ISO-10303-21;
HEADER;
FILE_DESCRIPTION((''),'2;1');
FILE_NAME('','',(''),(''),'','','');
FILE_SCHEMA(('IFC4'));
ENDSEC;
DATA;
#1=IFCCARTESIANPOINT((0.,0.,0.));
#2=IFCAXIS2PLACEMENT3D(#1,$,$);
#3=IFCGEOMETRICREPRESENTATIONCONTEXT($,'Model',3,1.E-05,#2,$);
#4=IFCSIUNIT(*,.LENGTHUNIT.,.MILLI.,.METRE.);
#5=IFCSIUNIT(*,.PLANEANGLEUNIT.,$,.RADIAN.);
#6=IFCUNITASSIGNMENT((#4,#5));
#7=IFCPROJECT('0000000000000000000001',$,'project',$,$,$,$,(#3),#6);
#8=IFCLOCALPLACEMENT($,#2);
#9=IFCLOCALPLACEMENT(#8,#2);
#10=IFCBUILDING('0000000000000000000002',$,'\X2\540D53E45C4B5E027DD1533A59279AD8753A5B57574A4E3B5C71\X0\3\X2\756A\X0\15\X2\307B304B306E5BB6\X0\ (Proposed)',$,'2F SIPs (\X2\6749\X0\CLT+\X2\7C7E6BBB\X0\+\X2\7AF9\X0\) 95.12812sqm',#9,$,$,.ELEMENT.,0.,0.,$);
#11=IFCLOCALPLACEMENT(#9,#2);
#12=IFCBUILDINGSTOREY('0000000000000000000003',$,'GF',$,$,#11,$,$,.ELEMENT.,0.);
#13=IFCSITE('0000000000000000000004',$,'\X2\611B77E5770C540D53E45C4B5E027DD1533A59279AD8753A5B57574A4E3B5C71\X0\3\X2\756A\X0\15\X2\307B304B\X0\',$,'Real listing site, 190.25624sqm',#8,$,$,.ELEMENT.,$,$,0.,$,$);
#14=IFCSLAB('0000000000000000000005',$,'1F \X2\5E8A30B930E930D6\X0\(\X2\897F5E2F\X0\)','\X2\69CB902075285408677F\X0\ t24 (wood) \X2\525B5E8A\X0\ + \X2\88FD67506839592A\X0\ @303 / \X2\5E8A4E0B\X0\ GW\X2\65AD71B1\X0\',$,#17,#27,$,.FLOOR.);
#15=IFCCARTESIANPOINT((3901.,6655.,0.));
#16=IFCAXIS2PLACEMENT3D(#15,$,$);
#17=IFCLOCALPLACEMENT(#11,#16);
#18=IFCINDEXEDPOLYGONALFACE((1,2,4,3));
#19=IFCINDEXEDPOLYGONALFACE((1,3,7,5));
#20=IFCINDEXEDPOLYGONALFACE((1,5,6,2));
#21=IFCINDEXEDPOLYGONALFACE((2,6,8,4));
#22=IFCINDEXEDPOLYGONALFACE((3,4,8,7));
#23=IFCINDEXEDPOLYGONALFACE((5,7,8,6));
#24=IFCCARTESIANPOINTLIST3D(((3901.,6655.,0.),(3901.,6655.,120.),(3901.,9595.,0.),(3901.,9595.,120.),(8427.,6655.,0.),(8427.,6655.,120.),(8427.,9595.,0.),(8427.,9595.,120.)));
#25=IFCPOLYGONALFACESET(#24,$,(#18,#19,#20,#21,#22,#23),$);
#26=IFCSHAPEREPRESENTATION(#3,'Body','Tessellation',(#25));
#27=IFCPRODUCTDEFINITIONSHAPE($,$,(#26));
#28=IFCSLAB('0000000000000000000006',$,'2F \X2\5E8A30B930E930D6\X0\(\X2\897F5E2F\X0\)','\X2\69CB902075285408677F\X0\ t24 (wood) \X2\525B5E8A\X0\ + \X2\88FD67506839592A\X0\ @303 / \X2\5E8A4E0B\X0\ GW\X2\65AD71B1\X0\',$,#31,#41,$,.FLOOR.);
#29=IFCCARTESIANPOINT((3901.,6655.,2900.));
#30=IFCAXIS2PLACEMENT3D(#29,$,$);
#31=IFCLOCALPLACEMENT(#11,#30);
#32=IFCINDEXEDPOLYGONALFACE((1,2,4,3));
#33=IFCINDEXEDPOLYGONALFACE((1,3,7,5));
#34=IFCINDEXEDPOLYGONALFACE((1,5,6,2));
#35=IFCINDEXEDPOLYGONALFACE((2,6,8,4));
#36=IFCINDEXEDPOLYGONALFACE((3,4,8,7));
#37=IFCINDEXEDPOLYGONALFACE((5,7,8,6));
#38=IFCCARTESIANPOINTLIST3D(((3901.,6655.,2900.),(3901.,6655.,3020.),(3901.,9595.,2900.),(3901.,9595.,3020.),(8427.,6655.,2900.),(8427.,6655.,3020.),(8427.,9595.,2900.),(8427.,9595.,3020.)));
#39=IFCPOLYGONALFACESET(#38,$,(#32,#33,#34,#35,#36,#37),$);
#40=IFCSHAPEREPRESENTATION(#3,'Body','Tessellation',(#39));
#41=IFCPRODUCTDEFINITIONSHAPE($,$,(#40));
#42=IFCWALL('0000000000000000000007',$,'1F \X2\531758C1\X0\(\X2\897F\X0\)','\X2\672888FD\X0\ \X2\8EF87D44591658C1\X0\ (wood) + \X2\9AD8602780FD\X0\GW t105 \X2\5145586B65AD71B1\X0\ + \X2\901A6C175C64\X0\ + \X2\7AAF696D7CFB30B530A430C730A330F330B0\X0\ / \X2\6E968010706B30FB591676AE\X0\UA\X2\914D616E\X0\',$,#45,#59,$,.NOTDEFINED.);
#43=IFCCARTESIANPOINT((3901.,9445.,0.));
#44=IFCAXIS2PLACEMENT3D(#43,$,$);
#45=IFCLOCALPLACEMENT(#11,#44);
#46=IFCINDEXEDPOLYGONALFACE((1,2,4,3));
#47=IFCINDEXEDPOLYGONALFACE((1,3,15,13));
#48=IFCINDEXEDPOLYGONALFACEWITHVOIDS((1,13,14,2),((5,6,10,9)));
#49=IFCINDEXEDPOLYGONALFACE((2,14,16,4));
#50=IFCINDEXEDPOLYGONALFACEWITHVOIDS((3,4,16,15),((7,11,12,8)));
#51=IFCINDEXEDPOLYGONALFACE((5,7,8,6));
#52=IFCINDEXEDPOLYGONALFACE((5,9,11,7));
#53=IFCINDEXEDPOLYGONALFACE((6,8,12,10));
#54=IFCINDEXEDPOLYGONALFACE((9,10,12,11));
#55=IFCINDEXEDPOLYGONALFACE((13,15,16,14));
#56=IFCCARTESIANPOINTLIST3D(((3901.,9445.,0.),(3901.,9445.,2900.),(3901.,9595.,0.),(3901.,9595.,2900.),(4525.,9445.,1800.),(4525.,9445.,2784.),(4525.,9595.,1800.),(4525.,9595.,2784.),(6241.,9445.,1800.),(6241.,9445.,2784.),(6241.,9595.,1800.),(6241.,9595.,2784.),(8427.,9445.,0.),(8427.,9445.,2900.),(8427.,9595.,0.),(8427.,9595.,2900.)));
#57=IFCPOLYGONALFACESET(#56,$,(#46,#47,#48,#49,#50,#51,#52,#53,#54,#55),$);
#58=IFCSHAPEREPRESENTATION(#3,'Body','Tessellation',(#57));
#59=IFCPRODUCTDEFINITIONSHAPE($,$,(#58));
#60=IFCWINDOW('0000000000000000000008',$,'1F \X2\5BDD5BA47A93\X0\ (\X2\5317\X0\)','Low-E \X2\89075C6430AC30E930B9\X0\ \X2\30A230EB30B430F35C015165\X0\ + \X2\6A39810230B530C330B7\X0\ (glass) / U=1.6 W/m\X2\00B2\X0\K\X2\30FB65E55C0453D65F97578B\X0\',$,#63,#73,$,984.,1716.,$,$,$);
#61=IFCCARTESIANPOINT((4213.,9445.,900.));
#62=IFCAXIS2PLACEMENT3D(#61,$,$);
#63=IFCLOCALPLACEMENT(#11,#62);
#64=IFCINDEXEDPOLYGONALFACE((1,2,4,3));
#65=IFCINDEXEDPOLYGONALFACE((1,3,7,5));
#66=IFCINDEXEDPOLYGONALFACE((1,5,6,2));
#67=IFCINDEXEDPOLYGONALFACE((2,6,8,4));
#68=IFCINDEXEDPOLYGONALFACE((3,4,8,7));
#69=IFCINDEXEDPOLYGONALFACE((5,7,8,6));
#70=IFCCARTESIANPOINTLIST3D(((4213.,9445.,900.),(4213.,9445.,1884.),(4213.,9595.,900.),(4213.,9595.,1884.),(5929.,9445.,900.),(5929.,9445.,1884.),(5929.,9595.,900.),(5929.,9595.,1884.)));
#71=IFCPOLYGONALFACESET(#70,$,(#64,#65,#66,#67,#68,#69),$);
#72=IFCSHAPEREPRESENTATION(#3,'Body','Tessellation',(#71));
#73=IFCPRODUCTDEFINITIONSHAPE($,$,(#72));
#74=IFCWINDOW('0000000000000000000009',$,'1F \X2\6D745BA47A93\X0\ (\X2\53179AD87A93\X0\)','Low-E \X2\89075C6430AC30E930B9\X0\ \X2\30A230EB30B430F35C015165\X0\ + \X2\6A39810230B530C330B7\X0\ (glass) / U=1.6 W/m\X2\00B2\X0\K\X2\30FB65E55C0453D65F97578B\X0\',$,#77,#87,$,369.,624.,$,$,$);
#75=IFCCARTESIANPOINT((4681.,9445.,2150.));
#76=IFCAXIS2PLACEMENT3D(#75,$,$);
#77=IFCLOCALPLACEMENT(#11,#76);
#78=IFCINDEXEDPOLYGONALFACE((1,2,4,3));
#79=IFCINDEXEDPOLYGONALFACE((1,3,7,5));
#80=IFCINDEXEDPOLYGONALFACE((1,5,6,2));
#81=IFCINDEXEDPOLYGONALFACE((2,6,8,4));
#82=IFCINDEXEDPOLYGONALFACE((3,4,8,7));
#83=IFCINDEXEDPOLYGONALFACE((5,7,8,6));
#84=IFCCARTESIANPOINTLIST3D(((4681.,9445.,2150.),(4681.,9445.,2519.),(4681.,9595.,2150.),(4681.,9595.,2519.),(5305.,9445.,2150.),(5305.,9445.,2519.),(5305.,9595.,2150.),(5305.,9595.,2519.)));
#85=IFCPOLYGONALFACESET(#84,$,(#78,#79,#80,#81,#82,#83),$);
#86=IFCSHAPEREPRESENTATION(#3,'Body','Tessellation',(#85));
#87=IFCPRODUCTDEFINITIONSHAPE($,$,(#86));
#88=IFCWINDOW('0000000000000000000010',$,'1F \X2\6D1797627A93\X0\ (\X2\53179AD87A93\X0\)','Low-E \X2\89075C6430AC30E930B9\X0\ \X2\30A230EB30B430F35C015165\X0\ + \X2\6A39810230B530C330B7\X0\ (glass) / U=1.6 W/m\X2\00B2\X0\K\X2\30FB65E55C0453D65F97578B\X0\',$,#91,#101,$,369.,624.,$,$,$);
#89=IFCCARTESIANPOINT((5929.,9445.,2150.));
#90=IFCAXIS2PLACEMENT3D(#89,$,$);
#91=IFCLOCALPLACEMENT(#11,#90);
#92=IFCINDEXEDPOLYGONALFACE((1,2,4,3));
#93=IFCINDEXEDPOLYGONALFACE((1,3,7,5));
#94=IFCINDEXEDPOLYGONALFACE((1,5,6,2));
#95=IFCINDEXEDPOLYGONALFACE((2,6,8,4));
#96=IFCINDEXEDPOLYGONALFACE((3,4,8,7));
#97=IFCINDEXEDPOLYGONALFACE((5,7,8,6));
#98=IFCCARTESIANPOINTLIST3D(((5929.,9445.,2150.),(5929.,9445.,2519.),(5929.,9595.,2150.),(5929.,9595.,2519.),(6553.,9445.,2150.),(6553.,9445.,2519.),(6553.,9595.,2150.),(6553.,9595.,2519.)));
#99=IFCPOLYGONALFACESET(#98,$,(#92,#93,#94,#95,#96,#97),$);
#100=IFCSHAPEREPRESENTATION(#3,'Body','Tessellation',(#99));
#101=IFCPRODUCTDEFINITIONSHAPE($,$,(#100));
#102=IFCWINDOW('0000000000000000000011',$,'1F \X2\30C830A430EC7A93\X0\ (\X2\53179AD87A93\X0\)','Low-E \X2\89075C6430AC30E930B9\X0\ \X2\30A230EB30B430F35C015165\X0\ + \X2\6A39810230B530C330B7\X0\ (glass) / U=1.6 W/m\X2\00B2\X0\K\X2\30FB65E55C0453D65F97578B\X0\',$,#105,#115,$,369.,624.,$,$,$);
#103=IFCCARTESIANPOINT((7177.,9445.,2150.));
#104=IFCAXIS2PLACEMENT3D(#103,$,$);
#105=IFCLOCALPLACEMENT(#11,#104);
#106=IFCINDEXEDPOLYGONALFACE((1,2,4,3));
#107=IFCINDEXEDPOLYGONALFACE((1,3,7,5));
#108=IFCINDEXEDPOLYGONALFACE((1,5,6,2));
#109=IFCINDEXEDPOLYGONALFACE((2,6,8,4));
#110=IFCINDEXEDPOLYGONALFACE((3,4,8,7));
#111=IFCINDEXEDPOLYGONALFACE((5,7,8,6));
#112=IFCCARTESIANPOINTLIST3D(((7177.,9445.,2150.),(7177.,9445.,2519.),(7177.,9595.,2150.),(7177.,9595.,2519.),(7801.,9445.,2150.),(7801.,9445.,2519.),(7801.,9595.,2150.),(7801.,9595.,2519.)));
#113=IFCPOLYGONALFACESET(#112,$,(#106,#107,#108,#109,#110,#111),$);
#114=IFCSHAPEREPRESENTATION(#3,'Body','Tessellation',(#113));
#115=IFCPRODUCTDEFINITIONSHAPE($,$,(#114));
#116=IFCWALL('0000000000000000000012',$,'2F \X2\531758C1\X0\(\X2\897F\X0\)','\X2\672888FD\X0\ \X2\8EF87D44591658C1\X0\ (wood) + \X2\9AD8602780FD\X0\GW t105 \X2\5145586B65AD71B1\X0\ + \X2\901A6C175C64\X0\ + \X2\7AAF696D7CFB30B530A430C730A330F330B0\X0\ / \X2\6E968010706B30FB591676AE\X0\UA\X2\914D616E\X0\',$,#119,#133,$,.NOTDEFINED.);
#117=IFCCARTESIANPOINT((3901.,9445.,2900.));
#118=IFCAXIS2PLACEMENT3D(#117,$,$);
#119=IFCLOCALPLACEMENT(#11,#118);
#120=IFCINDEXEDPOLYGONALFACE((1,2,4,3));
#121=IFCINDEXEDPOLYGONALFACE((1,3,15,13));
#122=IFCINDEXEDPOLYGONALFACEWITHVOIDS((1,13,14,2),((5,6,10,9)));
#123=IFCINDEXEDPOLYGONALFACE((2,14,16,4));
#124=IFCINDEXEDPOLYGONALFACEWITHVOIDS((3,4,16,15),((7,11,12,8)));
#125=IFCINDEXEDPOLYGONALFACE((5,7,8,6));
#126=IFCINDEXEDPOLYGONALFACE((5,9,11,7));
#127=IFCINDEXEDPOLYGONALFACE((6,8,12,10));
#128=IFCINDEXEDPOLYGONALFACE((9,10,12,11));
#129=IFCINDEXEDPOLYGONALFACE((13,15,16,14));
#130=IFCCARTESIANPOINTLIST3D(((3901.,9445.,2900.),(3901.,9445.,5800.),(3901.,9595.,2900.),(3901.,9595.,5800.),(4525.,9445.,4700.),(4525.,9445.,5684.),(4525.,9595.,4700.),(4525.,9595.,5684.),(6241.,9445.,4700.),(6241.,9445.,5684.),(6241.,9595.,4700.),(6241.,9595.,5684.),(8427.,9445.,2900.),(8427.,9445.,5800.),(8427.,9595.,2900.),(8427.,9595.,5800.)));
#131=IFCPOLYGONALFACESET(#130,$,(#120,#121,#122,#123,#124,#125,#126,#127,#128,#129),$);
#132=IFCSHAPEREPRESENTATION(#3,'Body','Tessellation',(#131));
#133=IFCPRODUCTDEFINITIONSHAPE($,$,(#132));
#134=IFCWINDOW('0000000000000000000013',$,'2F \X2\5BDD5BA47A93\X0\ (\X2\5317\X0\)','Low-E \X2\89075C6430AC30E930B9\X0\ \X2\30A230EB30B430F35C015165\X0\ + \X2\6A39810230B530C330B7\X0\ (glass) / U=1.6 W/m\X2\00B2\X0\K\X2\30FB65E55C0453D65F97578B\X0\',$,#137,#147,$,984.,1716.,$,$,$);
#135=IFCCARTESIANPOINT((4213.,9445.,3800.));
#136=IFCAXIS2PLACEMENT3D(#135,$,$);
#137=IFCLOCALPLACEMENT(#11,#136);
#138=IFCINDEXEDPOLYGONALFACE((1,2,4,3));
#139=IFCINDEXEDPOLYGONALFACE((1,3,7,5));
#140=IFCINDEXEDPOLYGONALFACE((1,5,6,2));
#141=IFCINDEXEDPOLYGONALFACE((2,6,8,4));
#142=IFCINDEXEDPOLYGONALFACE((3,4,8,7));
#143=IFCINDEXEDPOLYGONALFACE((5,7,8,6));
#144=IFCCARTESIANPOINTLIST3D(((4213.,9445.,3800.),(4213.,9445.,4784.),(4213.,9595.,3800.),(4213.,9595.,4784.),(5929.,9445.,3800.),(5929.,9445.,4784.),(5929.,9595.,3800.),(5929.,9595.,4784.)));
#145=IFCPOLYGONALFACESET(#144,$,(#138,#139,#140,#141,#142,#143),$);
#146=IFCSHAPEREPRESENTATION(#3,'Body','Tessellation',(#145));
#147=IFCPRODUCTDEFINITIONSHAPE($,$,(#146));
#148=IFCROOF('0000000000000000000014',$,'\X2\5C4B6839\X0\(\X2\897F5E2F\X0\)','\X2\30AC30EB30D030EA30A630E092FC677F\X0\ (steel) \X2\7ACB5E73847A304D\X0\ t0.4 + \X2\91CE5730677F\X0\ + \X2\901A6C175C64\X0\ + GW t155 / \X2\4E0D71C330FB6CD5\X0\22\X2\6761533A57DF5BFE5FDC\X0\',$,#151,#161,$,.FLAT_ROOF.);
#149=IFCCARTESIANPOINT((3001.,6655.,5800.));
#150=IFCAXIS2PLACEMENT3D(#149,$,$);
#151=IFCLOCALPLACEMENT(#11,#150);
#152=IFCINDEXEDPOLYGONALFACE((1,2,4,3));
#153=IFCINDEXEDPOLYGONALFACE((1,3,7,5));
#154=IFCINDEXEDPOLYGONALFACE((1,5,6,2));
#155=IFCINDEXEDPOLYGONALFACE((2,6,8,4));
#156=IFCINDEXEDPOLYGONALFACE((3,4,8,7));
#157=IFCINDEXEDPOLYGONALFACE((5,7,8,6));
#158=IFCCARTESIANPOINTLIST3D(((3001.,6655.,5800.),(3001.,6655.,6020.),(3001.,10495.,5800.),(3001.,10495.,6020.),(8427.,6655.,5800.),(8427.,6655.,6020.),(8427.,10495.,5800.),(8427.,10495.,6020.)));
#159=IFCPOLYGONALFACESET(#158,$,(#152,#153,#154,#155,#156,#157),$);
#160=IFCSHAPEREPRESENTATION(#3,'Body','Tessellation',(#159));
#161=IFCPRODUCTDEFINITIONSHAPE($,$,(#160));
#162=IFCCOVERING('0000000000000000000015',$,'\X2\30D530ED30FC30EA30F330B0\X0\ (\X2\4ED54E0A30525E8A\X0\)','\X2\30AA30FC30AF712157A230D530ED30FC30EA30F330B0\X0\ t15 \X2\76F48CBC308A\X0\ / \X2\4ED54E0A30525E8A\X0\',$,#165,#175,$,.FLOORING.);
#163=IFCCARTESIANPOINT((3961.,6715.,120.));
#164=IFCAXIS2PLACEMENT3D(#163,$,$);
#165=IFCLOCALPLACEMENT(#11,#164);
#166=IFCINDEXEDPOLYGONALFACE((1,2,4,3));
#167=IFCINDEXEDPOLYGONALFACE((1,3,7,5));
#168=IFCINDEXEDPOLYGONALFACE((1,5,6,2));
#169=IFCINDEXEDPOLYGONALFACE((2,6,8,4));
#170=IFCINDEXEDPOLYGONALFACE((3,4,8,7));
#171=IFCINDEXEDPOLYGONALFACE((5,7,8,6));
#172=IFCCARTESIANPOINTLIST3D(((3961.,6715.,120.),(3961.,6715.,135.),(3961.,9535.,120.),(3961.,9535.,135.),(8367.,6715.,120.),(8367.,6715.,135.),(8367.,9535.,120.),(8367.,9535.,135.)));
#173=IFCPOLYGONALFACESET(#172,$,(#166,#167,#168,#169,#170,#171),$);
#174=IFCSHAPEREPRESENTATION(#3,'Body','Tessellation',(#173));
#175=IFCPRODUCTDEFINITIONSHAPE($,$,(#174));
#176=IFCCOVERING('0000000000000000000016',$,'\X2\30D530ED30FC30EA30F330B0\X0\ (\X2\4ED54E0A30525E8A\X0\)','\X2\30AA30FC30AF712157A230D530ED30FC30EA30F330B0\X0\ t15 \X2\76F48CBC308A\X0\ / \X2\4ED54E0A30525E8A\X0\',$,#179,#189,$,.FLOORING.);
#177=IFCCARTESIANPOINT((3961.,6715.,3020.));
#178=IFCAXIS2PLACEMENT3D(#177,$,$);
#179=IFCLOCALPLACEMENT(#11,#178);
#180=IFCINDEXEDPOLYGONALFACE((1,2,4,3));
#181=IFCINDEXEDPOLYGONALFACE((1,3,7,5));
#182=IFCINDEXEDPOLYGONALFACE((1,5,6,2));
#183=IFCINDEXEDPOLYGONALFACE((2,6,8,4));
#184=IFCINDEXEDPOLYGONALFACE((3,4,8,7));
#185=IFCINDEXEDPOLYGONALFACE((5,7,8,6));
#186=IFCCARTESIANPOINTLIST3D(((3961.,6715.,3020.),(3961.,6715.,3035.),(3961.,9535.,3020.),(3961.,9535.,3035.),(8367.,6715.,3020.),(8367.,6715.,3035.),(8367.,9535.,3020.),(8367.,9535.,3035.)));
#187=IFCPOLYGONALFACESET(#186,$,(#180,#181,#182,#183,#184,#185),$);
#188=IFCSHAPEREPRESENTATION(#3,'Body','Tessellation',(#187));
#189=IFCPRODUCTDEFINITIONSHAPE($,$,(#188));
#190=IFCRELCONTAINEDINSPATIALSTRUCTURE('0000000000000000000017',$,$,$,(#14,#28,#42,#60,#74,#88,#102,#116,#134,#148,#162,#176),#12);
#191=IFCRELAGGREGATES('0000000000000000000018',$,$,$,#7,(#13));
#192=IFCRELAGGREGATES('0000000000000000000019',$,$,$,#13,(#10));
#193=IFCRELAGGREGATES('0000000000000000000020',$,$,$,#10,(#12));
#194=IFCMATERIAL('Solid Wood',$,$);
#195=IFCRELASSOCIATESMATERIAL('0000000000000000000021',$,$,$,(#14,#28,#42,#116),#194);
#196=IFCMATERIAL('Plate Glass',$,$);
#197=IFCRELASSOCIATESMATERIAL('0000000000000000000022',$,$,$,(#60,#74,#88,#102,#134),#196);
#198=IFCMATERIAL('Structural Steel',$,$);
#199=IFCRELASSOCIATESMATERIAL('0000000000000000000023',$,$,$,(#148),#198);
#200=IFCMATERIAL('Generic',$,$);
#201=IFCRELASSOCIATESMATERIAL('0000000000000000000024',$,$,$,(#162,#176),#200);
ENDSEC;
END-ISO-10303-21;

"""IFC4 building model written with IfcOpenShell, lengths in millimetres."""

from ifc_helpers import new_model, si_unit, frame, frame_2d, origin, place, context, project, spatial, rectangle, extrude, material, element, fill, save


model = new_model("IFC4")

# Units and contexts
model_context = context("Model", 3, precision=1e-05, world=origin())
ifc_project = project(units=[si_unit("LENGTHUNIT", "METRE", prefix="MILLI"), si_unit("PLANEANGLEUNIT", "RADIAN")], contexts=[model_context])

# Site, building, storey
site_placement = place(None, origin())
site = spatial("IfcSite", under=ifc_project, at=site_placement, Name="愛知県名古屋市緑区大高町字坊主山3番15ほか", ObjectType="Real listing site, 190.25624sqm", CompositionType="ELEMENT", RefElevation=0.0)
building_placement = place(site_placement, origin())
building = spatial("IfcBuilding", under=site, at=building_placement, Name="名古屋市緑区大高町字坊主山3番15ほかの家 (Proposed)", ObjectType="2F SIPs (杉CLT+籾殻+竹) 95.12812sqm", CompositionType="ELEMENT", ElevationOfRefHeight=0.0, ElevationOfTerrain=0.0)
storey_placement = place(building_placement, origin())
storey = spatial("IfcBuildingStorey", under=building, at=storey_placement, Name="GF", CompositionType="ELEMENT", Elevation=0.0)

# Slabs
ifc_material_1 = material(Name="Solid Wood")
slab_1_placement = place(storey_placement, frame((3901.0, 6655.0, 0.0)))
element("IfcSlab", 1, at=slab_1_placement, inside=storey, material=ifc_material_1, Name="1F 床スラブ(西帯)", Description="構造用合板 t24 (wood) 剛床 + 製材根太 @303 / 床下 GW断熱", PredefinedType="FLOOR", context=model_context, shape_type="SweptSolid", body=[
    extrude(rectangle(XDim=4526.0, YDim=2940.0, at=frame_2d((2263.0, 1470.0))), frame((3901.0, 6655.0, 0.0)), (0.0, 0.0, 1.0), 120.0),
])
slab_2_placement = place(storey_placement, frame((3901.0, 6655.0, 2900.0)))
element("IfcSlab", 2, at=slab_2_placement, inside=storey, material=ifc_material_1, Name="2F 床スラブ(西帯)", Description="構造用合板 t24 (wood) 剛床 + 製材根太 @303 / 床下 GW断熱", PredefinedType="FLOOR", context=model_context, shape_type="SweptSolid", body=[
    extrude(rectangle(XDim=4526.0, YDim=2940.0, at=frame_2d((2263.0, 1470.0))), frame((3901.0, 6655.0, 2900.0)), (0.0, 0.0, 1.0), 120.0),
])

# Wall, openings, windows
wall_1_placement = place(storey_placement, frame((3901.0, 9445.0, 0.0)))
wall_1 = element("IfcWall", 3, at=wall_1_placement, inside=storey, material=ifc_material_1, Name="1F 北壁(西)", Description="木製 軸組外壁 (wood) + 高性能GW t105 充填断熱 + 通気層 + 窯業系サイディング / 準耐火・外皮UA配慮", PredefinedType="NOTDEFINED", context=model_context, shape_type="SweptSolid", body=[
    extrude(rectangle(XDim=4526.0, YDim=150.0, at=frame_2d((2263.0, 75.0))), frame((3901.0, 9445.0, 0.0)), (0.0, 0.0, 1.0), 2900.0),
])
opening_1_placement = place(storey_placement, frame((4213.0, 9445.0, 900.0)))
opening_1 = element("IfcOpeningElement", 4, at=opening_1_placement, cuts=wall_1, PredefinedType="NOTDEFINED", context=model_context, shape_type="SweptSolid", body=[
    extrude(rectangle(XDim=1716.0, YDim=150.0, at=frame_2d((858.0, 75.0))), frame((4213.0, 9445.0, 900.0)), (0.0, 0.0, 1.0), 984.0),
])
opening_2_placement = place(storey_placement, frame((4681.0, 9445.0, 2150.0)))
opening_2 = element("IfcOpeningElement", 5, at=opening_2_placement, cuts=wall_1, PredefinedType="NOTDEFINED", context=model_context, shape_type="SweptSolid", body=[
    extrude(rectangle(XDim=624.0, YDim=150.0, at=frame_2d((312.0, 75.0))), frame((4681.0, 9445.0, 2150.0)), (0.0, 0.0, 1.0), 369.0),
])
opening_3_placement = place(storey_placement, frame((5929.0, 9445.0, 2150.0)))
opening_3 = element("IfcOpeningElement", 6, at=opening_3_placement, cuts=wall_1, PredefinedType="NOTDEFINED", context=model_context, shape_type="SweptSolid", body=[
    extrude(rectangle(XDim=624.0, YDim=150.0, at=frame_2d((312.0, 75.0))), frame((5929.0, 9445.0, 2150.0)), (0.0, 0.0, 1.0), 369.0),
])
opening_4_placement = place(storey_placement, frame((7177.0, 9445.0, 2150.0)))
opening_4 = element("IfcOpeningElement", 7, at=opening_4_placement, cuts=wall_1, PredefinedType="NOTDEFINED", context=model_context, shape_type="SweptSolid", body=[
    extrude(rectangle(XDim=624.0, YDim=150.0, at=frame_2d((312.0, 75.0))), frame((7177.0, 9445.0, 2150.0)), (0.0, 0.0, 1.0), 369.0),
])
ifc_material_2 = material(Name="Plate Glass")
window_1_placement = place(storey_placement, frame((4213.0, 9445.0, 900.0)))
window_1 = element("IfcWindow", 8, at=window_1_placement, inside=storey, material=ifc_material_2, Name="1F 寝室窓 (北)", Description="Low-E 複層ガラス アルゴン封入 + 樹脂サッシ (glass) / U=1.6 W/m²K・日射取得型", OverallHeight=984.0, OverallWidth=1716.0, context=model_context, shape_type="SweptSolid", body=[
    extrude(rectangle(XDim=1716.0, YDim=150.0, at=frame_2d((858.0, 75.0))), frame((4213.0, 9445.0, 900.0)), (0.0, 0.0, 1.0), 984.0),
])
fill(opening_1, window_1)
window_2_placement = place(storey_placement, frame((4681.0, 9445.0, 2150.0)))
window_2 = element("IfcWindow", 9, at=window_2_placement, inside=storey, material=ifc_material_2, Name="1F 浴室窓 (北高窓)", Description="Low-E 複層ガラス アルゴン封入 + 樹脂サッシ (glass) / U=1.6 W/m²K・日射取得型", OverallHeight=369.0, OverallWidth=624.0, context=model_context, shape_type="SweptSolid", body=[
    extrude(rectangle(XDim=624.0, YDim=150.0, at=frame_2d((312.0, 75.0))), frame((4681.0, 9445.0, 2150.0)), (0.0, 0.0, 1.0), 369.0),
])
fill(opening_2, window_2)
window_3_placement = place(storey_placement, frame((5929.0, 9445.0, 2150.0)))
window_3 = element("IfcWindow", 10, at=window_3_placement, inside=storey, material=ifc_material_2, Name="1F 洗面窓 (北高窓)", Description="Low-E 複層ガラス アルゴン封入 + 樹脂サッシ (glass) / U=1.6 W/m²K・日射取得型", OverallHeight=369.0, OverallWidth=624.0, context=model_context, shape_type="SweptSolid", body=[
    extrude(rectangle(XDim=624.0, YDim=150.0, at=frame_2d((312.0, 75.0))), frame((5929.0, 9445.0, 2150.0)), (0.0, 0.0, 1.0), 369.0),
])
fill(opening_3, window_3)
window_4_placement = place(storey_placement, frame((7177.0, 9445.0, 2150.0)))
window_4 = element("IfcWindow", 11, at=window_4_placement, inside=storey, material=ifc_material_2, Name="1F トイレ窓 (北高窓)", Description="Low-E 複層ガラス アルゴン封入 + 樹脂サッシ (glass) / U=1.6 W/m²K・日射取得型", OverallHeight=369.0, OverallWidth=624.0, context=model_context, shape_type="SweptSolid", body=[
    extrude(rectangle(XDim=624.0, YDim=150.0, at=frame_2d((312.0, 75.0))), frame((7177.0, 9445.0, 2150.0)), (0.0, 0.0, 1.0), 369.0),
])
fill(opening_4, window_4)

# Wall, opening, window
wall_2_placement = place(storey_placement, frame((3901.0, 9445.0, 2900.0)))
wall_2 = element("IfcWall", 12, at=wall_2_placement, inside=storey, material=ifc_material_1, Name="2F 北壁(西)", Description="木製 軸組外壁 (wood) + 高性能GW t105 充填断熱 + 通気層 + 窯業系サイディング / 準耐火・外皮UA配慮", PredefinedType="NOTDEFINED", context=model_context, shape_type="SweptSolid", body=[
    extrude(rectangle(XDim=4526.0, YDim=150.0, at=frame_2d((2263.0, 75.0))), frame((3901.0, 9445.0, 2900.0)), (0.0, 0.0, 1.0), 2900.0),
])
opening_5_placement = place(storey_placement, frame((4213.0, 9445.0, 3800.0)))
opening_5 = element("IfcOpeningElement", 13, at=opening_5_placement, cuts=wall_2, PredefinedType="NOTDEFINED", context=model_context, shape_type="SweptSolid", body=[
    extrude(rectangle(XDim=1716.0, YDim=150.0, at=frame_2d((858.0, 75.0))), frame((4213.0, 9445.0, 3800.0)), (0.0, 0.0, 1.0), 984.0),
])
window_5_placement = place(storey_placement, frame((4213.0, 9445.0, 3800.0)))
window_5 = element("IfcWindow", 14, at=window_5_placement, inside=storey, material=ifc_material_2, Name="2F 寝室窓 (北)", Description="Low-E 複層ガラス アルゴン封入 + 樹脂サッシ (glass) / U=1.6 W/m²K・日射取得型", OverallHeight=984.0, OverallWidth=1716.0, context=model_context, shape_type="SweptSolid", body=[
    extrude(rectangle(XDim=1716.0, YDim=150.0, at=frame_2d((858.0, 75.0))), frame((4213.0, 9445.0, 3800.0)), (0.0, 0.0, 1.0), 984.0),
])
fill(opening_5, window_5)

# Roof
ifc_material_3 = material(Name="Structural Steel")
for number, where, name in (
    (15, (3001.0, 6655.0, 5800.0), "屋根(西帯)"),
):
    element("IfcRoof", number, at=place(storey_placement, frame(where)), inside=storey, material=ifc_material_3, Name=name, Description="ガルバリウム鋼板 (steel) 立平葺き t0.4 + 野地板 + 通気層 + GW t155 / 不燃・法22条区域対応", PredefinedType="FLAT_ROOF", context=model_context, shape_type="SweptSolid", body=[
        extrude(rectangle(XDim=5426.0, YDim=3840.0, at=frame_2d((2713.0, 1920.0))), frame((3001.0, 6655.0, 5800.0)), (0.0, 0.0, 1.0), 220.0),
    ])

# Coverings
ifc_material_4 = material(Name="Generic")
covering_1_placement = place(storey_placement, frame((3961.0, 6715.0, 120.0)))
element("IfcCovering", 16, at=covering_1_placement, inside=storey, material=ifc_material_4, Name="フローリング (仕上げ床)", Description="オーク無垢フローリング t15 直貼り / 仕上げ床", PredefinedType="FLOORING", context=model_context, shape_type="SweptSolid", body=[
    extrude(rectangle(XDim=4406.0, YDim=2820.0, at=frame_2d((2203.0, 1410.0))), frame((3961.0, 6715.0, 120.0)), (0.0, 0.0, 1.0), 15.0),
])
covering_2_placement = place(storey_placement, frame((3961.0, 6715.0, 3020.0)))
element("IfcCovering", 17, at=covering_2_placement, inside=storey, material=ifc_material_4, Name="フローリング (仕上げ床)", Description="オーク無垢フローリング t15 直貼り / 仕上げ床", PredefinedType="FLOORING", context=model_context, shape_type="SweptSolid", body=[
    extrude(rectangle(XDim=4406.0, YDim=2820.0, at=frame_2d((2203.0, 1410.0))), frame((3961.0, 6715.0, 3020.0)), (0.0, 0.0, 1.0), 15.0),
])

save(model, "model.ifc")
